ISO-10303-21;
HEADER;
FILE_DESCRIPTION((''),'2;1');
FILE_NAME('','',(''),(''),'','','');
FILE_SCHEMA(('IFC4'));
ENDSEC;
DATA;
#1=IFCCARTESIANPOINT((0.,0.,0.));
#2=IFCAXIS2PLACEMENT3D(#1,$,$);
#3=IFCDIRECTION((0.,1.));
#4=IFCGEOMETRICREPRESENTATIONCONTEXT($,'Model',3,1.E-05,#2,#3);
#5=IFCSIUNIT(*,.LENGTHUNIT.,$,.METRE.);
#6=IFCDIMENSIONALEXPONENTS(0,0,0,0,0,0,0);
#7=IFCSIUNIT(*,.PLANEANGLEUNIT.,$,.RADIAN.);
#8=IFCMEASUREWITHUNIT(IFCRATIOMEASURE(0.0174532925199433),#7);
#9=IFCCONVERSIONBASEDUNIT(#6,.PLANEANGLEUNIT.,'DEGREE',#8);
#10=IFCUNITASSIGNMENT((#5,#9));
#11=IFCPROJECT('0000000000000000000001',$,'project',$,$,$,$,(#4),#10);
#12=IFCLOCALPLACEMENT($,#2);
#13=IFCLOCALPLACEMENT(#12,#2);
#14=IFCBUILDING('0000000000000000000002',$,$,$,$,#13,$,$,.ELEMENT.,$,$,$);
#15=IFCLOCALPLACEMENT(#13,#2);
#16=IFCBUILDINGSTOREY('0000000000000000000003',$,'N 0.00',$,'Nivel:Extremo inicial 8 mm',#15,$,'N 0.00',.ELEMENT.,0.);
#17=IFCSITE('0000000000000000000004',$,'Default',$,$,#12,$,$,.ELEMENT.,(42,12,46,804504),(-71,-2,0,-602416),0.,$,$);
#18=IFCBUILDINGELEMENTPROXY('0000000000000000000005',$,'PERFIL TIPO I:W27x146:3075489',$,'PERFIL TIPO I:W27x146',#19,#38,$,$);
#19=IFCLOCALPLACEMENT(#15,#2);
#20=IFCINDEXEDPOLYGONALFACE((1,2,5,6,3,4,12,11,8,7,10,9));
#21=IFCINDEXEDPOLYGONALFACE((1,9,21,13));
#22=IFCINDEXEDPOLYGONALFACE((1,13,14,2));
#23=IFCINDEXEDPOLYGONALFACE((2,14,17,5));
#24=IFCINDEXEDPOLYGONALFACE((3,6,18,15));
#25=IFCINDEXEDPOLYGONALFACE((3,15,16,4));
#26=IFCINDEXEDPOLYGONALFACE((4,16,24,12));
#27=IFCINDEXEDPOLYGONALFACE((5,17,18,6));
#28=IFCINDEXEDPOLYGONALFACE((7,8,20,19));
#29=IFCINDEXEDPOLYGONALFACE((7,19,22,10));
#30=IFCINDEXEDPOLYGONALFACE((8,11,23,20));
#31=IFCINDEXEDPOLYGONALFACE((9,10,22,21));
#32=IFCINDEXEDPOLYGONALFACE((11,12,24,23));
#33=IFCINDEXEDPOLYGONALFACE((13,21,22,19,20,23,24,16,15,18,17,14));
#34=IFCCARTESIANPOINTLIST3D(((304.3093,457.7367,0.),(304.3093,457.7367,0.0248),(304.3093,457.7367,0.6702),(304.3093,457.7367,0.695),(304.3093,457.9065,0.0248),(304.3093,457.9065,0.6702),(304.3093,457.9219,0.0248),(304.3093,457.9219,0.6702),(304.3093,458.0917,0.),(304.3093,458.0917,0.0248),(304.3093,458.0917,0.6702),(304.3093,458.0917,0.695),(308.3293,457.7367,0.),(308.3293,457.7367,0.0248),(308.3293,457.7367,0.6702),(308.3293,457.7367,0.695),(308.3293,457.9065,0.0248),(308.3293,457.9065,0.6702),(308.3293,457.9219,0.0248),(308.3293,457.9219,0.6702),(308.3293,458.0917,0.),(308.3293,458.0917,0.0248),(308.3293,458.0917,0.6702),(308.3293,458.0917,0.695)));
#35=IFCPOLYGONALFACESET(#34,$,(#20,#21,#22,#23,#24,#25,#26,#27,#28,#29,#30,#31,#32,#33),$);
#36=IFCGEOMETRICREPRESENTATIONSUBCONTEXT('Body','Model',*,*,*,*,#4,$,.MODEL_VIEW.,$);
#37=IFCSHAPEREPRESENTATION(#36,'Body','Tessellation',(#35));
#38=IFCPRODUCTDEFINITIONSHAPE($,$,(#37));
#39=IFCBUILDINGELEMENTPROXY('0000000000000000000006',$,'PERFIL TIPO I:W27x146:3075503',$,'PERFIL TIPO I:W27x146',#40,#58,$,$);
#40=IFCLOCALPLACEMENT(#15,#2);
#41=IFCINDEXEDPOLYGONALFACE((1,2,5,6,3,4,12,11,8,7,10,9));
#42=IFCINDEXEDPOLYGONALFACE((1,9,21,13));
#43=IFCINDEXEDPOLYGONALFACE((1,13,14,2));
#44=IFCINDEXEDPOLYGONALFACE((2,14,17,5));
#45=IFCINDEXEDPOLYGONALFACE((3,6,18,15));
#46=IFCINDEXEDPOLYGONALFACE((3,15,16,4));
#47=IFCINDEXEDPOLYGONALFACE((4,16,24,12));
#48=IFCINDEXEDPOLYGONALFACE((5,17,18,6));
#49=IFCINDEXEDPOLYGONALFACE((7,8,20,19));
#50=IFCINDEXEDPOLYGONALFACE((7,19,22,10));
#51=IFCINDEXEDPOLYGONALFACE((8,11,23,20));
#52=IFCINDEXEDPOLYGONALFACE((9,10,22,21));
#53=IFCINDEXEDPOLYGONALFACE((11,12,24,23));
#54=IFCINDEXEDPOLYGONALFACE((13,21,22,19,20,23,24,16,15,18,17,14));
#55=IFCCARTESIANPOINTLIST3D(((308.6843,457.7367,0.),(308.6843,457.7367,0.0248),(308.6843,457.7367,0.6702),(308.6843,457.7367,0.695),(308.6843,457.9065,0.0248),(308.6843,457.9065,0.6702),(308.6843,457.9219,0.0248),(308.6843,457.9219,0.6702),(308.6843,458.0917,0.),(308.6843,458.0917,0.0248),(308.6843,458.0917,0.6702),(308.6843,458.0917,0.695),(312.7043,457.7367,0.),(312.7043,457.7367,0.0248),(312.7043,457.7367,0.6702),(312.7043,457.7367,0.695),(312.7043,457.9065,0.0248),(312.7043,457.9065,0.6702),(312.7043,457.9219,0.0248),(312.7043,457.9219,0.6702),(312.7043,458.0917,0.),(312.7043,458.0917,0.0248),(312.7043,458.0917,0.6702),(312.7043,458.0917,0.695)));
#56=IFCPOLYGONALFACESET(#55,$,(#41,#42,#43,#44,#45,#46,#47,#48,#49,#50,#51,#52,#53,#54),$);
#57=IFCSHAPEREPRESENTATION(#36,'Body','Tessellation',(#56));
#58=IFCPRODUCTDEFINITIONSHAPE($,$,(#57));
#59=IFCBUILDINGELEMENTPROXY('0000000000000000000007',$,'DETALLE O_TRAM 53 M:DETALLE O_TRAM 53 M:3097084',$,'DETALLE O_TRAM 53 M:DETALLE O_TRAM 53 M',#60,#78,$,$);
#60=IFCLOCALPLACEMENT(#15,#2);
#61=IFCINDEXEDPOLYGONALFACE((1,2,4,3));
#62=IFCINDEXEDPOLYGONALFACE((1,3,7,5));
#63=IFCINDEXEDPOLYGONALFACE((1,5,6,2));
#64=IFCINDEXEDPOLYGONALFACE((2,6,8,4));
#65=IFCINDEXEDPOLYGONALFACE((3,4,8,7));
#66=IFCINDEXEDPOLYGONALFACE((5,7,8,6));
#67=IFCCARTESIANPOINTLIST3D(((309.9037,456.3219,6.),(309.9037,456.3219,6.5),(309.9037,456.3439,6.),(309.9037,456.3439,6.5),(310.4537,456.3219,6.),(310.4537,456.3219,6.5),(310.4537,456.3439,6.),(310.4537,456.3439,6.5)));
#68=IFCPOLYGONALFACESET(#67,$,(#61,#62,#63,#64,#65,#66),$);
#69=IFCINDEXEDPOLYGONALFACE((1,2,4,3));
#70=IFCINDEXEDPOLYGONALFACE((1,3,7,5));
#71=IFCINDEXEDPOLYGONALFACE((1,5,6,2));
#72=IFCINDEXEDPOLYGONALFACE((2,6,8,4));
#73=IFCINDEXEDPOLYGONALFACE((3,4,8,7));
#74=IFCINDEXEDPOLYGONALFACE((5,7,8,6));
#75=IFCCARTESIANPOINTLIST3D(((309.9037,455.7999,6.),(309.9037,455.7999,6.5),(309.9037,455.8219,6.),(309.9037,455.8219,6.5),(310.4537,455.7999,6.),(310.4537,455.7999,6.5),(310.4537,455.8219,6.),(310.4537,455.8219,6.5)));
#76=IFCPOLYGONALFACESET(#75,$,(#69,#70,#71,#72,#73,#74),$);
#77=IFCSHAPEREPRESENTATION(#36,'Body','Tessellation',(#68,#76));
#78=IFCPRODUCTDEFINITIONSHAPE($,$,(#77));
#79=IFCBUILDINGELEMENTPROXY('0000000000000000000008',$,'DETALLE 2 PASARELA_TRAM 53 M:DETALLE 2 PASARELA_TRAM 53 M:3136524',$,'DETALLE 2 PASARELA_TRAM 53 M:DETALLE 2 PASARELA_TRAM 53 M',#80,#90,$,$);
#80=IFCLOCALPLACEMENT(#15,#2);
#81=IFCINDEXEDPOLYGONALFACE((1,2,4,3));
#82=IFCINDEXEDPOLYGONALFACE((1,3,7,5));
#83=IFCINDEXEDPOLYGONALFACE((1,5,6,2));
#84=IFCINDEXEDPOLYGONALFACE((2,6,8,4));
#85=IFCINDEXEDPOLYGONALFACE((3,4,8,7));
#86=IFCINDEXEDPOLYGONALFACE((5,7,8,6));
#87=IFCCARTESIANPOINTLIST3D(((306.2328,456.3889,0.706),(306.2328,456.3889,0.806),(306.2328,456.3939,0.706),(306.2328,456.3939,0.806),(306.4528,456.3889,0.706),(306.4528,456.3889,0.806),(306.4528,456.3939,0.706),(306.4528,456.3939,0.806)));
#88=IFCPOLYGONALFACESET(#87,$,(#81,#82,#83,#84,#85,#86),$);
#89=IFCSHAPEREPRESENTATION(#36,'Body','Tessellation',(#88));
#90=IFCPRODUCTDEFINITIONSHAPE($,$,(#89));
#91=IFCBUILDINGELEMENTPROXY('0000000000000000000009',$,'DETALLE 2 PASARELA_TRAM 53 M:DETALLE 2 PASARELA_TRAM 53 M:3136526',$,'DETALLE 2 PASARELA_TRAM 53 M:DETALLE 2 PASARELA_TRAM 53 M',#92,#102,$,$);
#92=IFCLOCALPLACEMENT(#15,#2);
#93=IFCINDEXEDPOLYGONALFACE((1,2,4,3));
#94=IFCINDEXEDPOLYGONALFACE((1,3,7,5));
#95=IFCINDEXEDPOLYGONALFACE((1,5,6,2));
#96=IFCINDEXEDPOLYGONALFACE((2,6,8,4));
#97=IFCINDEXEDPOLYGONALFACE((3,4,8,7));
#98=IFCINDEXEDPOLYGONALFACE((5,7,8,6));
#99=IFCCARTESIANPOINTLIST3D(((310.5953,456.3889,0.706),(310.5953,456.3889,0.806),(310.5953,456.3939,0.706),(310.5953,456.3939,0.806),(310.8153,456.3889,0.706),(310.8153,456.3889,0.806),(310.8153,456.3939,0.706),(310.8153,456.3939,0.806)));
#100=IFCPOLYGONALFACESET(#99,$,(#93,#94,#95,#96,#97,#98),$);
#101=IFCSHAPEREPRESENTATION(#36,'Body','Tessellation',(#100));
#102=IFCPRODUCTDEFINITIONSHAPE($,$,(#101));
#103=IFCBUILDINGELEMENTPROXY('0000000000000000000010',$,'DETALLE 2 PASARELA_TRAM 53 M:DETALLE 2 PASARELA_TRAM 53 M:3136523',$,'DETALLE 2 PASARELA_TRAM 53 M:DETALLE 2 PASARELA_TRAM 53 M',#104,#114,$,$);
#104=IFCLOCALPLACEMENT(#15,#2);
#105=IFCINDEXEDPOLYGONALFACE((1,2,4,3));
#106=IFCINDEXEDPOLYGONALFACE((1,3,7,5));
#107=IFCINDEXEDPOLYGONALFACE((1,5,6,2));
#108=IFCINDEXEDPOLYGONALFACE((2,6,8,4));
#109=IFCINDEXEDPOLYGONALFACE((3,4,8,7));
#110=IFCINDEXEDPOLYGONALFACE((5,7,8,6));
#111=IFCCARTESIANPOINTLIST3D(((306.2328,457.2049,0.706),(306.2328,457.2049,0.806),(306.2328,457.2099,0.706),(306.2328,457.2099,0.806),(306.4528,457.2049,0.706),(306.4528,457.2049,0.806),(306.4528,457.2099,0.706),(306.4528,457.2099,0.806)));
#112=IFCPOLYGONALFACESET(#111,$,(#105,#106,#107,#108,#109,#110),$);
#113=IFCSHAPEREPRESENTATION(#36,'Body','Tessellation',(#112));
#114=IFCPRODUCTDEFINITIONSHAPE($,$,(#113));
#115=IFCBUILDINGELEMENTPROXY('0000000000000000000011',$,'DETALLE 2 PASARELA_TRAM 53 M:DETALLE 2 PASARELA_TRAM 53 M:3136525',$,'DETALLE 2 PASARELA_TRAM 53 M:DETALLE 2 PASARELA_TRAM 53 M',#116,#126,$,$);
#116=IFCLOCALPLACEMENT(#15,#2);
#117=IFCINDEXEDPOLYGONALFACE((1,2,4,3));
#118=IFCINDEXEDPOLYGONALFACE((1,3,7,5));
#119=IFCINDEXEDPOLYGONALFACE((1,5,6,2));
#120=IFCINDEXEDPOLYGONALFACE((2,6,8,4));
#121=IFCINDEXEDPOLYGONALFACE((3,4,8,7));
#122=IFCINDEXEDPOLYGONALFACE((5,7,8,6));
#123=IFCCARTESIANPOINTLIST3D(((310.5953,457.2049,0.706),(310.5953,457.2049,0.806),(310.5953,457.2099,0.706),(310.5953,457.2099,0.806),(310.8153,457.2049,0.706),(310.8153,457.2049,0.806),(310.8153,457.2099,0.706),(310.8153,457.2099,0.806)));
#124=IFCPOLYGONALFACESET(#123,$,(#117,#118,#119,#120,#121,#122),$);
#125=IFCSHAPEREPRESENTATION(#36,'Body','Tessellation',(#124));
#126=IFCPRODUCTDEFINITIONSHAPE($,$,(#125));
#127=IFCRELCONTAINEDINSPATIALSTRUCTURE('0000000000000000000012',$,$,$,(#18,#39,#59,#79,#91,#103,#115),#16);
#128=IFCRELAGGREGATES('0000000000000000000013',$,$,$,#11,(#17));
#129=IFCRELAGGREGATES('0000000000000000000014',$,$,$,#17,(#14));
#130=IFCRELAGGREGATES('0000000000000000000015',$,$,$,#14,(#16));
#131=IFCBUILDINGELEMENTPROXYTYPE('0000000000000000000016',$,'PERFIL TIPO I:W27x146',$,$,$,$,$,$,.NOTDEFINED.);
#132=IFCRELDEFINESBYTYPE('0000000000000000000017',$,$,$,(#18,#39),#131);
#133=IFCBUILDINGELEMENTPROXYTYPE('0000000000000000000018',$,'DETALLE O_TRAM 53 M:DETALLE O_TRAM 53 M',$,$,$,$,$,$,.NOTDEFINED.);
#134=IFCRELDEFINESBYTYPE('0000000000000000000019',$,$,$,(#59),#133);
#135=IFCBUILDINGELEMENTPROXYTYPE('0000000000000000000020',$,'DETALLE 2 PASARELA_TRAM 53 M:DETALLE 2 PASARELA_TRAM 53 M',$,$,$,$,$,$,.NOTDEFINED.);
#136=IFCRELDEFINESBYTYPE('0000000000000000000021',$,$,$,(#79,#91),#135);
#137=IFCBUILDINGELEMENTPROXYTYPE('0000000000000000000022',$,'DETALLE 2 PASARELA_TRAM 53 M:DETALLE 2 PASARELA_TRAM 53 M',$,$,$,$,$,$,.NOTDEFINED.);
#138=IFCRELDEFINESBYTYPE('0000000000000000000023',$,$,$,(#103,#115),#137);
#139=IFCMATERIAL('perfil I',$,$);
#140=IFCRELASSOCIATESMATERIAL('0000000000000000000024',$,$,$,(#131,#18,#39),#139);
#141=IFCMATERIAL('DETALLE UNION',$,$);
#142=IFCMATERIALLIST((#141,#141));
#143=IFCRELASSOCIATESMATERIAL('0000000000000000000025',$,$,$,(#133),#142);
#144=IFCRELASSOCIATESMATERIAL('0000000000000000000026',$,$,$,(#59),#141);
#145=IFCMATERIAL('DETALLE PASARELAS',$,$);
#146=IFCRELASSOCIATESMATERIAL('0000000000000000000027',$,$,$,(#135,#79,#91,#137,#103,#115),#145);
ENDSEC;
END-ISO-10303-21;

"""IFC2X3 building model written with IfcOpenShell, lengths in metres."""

from ifc_helpers import new_model, entity, si_unit, converted_unit, direction, frame, frame_2d, origin, place, context, subcontext, project, spatial, polyline, rectangle, outline, extrude, source, transform, mapped, material, material_list, type_object, type_shapes, element, save


model = new_model("IFC2X3")

# Units and contexts
model_context = context("Model", 3, precision=1e-05, world=origin(), true_north=direction((0.0, 1.0)))
body_context = subcontext(model_context, "Body", "Model", "MODEL_VIEW")
ifc_project = project(units=[si_unit("LENGTHUNIT", "METRE"), converted_unit("PLANEANGLEUNIT", "DEGREE", entity("IfcRatioMeasure", 0.0174532925199433), si_unit("PLANEANGLEUNIT", "RADIAN"), dimensions=[0, 0, 0, 0, 0, 0, 0])], contexts=[model_context])

# Site, building, storey
site_placement = place(None, origin())
site = spatial("IfcSite", under=ifc_project, at=site_placement, Name="Default", CompositionType="ELEMENT", RefLatitude=(42, 12, 46, 804504), RefLongitude=(-71, -2, 0, -602416), RefElevation=0.0)
building_placement = place(site_placement, origin())
building = spatial("IfcBuilding", under=site, at=building_placement, CompositionType="ELEMENT")
storey_placement = place(building_placement, origin())
storey = spatial("IfcBuildingStorey", under=building, at=storey_placement, Name="N 0.00", ObjectType="Nivel:Extremo inicial 8 mm", LongName="N 0.00", CompositionType="ELEMENT", Elevation=0.0)

# Building element proxies
ifc_material_1 = material(Name="perfil I")
building_element_proxy_type_1 = type_object("IfcBuildingElementProxyType", Name="PERFIL TIPO I:W27x146", PredefinedType="NOTDEFINED", material=ifc_material_1)
shared_shape_1 = source(origin(), body_context, "Body", "SweptSolid", [
    extrude(outline(polyline([(0.3227, -0.1775), (0.3475, -0.1775), (0.3475, 0.1775), (0.3227, 0.1775), (0.3227, 0.0077), (-0.3227, 0.0077), (-0.3227, 0.1775), (-0.3475, 0.1775), (-0.3475, -0.1775), (-0.3227, -0.1775), (-0.3227, -0.0077), (0.3227, -0.0077), (0.3227, -0.1775)])), frame((0.0, 0.0, 0.3475), z_axis=(1.0, 0.0, 0.0), x_axis=(0.0, 0.0, 1.0)), (0.0, 0.0, 1.0), 4.02),
])
type_shapes(building_element_proxy_type_1, [shared_shape_1])
for number, where, name in (
    (1, (304.3093, 457.9142, 0.0), "PERFIL TIPO I:W27x146:3075489"),
    (2, (308.6843, 457.9142, 0.0), "PERFIL TIPO I:W27x146:3075503"),
):
    element("IfcBuildingElementProxy", number, at=place(storey_placement, frame(where)), inside=storey, type_object=building_element_proxy_type_1, material=ifc_material_1, Name=name, ObjectType="PERFIL TIPO I:W27x146", context=body_context, shape_type="MappedRepresentation", body=[
        mapped(shared_shape_1, transform((0.0, 0.0, 0.0), scale=1.0)),
    ])
ifc_material_2 = material(Name="DETALLE UNION")
ifc_material_list_1 = material_list([ifc_material_2, ifc_material_2])
building_element_proxy_type_2 = type_object("IfcBuildingElementProxyType", Name="DETALLE O_TRAM 53 M:DETALLE O_TRAM 53 M", PredefinedType="NOTDEFINED", material=ifc_material_list_1)
shared_shape_2 = source(origin(), body_context, "Body", "SweptSolid", [
    extrude(rectangle(XDim=0.55, YDim=0.022, at=frame_2d((0.0, 0.0), x_axis=(1.0, 0.0))), frame((0.275, 0.011, 0.0), z_axis=(0.0, 0.0, 1.0), x_axis=(-1.0, 0.0, 0.0)), (0.0, 0.0, 1.0), 0.5),
    extrude(rectangle(XDim=0.55, YDim=0.022, at=frame_2d((0.0, 0.0), x_axis=(1.0, 0.0))), frame((0.275, -0.511, 0.0), z_axis=(0.0, 0.0, 1.0), x_axis=(-1.0, 0.0, 0.0)), (0.0, 0.0, 1.0), 0.5),
])
type_shapes(building_element_proxy_type_2, [shared_shape_2])
proxy_1_placement = place(storey_placement, frame((309.9037, 456.3219, 6.0)))
element("IfcBuildingElementProxy", 3, at=proxy_1_placement, inside=storey, type_object=building_element_proxy_type_2, material=ifc_material_2, Name="DETALLE O_TRAM 53 M:DETALLE O_TRAM 53 M:3097084", ObjectType="DETALLE O_TRAM 53 M:DETALLE O_TRAM 53 M", context=body_context, shape_type="MappedRepresentation", body=[
    mapped(shared_shape_2, transform((0.0, 0.0, 0.0), scale=1.0)),
])
ifc_material_3 = material(Name="DETALLE PASARELAS")
building_element_proxy_type_3 = type_object("IfcBuildingElementProxyType", Name="DETALLE 2 PASARELA_TRAM 53 M:DETALLE 2 PASARELA_TRAM 53 M", PredefinedType="NOTDEFINED", material=ifc_material_3)
shared_shape_3 = source(origin(), body_context, "Body", "SweptSolid", [
    extrude(rectangle(XDim=0.22, YDim=0.005, at=frame_2d((0.0, 0.0), x_axis=(1.0, 0.0))), frame((0.11, 0.0475, 0.0), z_axis=(0.0, 0.0, 1.0), x_axis=(-1.0, 0.0, 0.0)), (0.0, 0.0, 1.0), 0.1),
])
type_shapes(building_element_proxy_type_3, [shared_shape_3])
for number, where, name in (
    (4, (306.2328, 456.3439, 0.706), "DETALLE 2 PASARELA_TRAM 53 M:DETALLE 2 PASARELA_TRAM 53 M:3136524"),
    (5, (310.5953, 456.3439, 0.706), "DETALLE 2 PASARELA_TRAM 53 M:DETALLE 2 PASARELA_TRAM 53 M:3136526"),
):
    element("IfcBuildingElementProxy", number, at=place(storey_placement, frame(where)), inside=storey, type_object=building_element_proxy_type_3, material=ifc_material_3, Name=name, ObjectType="DETALLE 2 PASARELA_TRAM 53 M:DETALLE 2 PASARELA_TRAM 53 M", context=body_context, shape_type="MappedRepresentation", body=[
        mapped(shared_shape_3, transform((0.0, 0.0, 0.0), scale=1.0)),
    ])
building_element_proxy_type_4 = type_object("IfcBuildingElementProxyType", Name="DETALLE 2 PASARELA_TRAM 53 M:DETALLE 2 PASARELA_TRAM 53 M", PredefinedType="NOTDEFINED", material=ifc_material_3)
shared_shape_4 = source(origin(), body_context, "Body", "SweptSolid", [
    extrude(rectangle(XDim=0.005, YDim=0.22, at=frame_2d((0.0, 0.0), x_axis=(1.0, 0.0))), frame((0.11, -0.0475, 0.0), z_axis=(0.0, 0.0, 1.0), x_axis=(0.0, 1.0, 0.0)), (0.0, 0.0, 1.0), 0.1),
])
type_shapes(building_element_proxy_type_4, [shared_shape_4])
for number, where, name in (
    (6, (306.2328, 457.2549, 0.706), "DETALLE 2 PASARELA_TRAM 53 M:DETALLE 2 PASARELA_TRAM 53 M:3136523"),
    (7, (310.5953, 457.2549, 0.706), "DETALLE 2 PASARELA_TRAM 53 M:DETALLE 2 PASARELA_TRAM 53 M:3136525"),
):
    element("IfcBuildingElementProxy", number, at=place(storey_placement, frame(where)), inside=storey, type_object=building_element_proxy_type_4, material=ifc_material_3, Name=name, ObjectType="DETALLE 2 PASARELA_TRAM 53 M:DETALLE 2 PASARELA_TRAM 53 M", context=body_context, shape_type="MappedRepresentation", body=[
        mapped(shared_shape_4, transform((0.0, 0.0, 0.0), scale=1.0)),
    ])

save(model, "model.ifc")
